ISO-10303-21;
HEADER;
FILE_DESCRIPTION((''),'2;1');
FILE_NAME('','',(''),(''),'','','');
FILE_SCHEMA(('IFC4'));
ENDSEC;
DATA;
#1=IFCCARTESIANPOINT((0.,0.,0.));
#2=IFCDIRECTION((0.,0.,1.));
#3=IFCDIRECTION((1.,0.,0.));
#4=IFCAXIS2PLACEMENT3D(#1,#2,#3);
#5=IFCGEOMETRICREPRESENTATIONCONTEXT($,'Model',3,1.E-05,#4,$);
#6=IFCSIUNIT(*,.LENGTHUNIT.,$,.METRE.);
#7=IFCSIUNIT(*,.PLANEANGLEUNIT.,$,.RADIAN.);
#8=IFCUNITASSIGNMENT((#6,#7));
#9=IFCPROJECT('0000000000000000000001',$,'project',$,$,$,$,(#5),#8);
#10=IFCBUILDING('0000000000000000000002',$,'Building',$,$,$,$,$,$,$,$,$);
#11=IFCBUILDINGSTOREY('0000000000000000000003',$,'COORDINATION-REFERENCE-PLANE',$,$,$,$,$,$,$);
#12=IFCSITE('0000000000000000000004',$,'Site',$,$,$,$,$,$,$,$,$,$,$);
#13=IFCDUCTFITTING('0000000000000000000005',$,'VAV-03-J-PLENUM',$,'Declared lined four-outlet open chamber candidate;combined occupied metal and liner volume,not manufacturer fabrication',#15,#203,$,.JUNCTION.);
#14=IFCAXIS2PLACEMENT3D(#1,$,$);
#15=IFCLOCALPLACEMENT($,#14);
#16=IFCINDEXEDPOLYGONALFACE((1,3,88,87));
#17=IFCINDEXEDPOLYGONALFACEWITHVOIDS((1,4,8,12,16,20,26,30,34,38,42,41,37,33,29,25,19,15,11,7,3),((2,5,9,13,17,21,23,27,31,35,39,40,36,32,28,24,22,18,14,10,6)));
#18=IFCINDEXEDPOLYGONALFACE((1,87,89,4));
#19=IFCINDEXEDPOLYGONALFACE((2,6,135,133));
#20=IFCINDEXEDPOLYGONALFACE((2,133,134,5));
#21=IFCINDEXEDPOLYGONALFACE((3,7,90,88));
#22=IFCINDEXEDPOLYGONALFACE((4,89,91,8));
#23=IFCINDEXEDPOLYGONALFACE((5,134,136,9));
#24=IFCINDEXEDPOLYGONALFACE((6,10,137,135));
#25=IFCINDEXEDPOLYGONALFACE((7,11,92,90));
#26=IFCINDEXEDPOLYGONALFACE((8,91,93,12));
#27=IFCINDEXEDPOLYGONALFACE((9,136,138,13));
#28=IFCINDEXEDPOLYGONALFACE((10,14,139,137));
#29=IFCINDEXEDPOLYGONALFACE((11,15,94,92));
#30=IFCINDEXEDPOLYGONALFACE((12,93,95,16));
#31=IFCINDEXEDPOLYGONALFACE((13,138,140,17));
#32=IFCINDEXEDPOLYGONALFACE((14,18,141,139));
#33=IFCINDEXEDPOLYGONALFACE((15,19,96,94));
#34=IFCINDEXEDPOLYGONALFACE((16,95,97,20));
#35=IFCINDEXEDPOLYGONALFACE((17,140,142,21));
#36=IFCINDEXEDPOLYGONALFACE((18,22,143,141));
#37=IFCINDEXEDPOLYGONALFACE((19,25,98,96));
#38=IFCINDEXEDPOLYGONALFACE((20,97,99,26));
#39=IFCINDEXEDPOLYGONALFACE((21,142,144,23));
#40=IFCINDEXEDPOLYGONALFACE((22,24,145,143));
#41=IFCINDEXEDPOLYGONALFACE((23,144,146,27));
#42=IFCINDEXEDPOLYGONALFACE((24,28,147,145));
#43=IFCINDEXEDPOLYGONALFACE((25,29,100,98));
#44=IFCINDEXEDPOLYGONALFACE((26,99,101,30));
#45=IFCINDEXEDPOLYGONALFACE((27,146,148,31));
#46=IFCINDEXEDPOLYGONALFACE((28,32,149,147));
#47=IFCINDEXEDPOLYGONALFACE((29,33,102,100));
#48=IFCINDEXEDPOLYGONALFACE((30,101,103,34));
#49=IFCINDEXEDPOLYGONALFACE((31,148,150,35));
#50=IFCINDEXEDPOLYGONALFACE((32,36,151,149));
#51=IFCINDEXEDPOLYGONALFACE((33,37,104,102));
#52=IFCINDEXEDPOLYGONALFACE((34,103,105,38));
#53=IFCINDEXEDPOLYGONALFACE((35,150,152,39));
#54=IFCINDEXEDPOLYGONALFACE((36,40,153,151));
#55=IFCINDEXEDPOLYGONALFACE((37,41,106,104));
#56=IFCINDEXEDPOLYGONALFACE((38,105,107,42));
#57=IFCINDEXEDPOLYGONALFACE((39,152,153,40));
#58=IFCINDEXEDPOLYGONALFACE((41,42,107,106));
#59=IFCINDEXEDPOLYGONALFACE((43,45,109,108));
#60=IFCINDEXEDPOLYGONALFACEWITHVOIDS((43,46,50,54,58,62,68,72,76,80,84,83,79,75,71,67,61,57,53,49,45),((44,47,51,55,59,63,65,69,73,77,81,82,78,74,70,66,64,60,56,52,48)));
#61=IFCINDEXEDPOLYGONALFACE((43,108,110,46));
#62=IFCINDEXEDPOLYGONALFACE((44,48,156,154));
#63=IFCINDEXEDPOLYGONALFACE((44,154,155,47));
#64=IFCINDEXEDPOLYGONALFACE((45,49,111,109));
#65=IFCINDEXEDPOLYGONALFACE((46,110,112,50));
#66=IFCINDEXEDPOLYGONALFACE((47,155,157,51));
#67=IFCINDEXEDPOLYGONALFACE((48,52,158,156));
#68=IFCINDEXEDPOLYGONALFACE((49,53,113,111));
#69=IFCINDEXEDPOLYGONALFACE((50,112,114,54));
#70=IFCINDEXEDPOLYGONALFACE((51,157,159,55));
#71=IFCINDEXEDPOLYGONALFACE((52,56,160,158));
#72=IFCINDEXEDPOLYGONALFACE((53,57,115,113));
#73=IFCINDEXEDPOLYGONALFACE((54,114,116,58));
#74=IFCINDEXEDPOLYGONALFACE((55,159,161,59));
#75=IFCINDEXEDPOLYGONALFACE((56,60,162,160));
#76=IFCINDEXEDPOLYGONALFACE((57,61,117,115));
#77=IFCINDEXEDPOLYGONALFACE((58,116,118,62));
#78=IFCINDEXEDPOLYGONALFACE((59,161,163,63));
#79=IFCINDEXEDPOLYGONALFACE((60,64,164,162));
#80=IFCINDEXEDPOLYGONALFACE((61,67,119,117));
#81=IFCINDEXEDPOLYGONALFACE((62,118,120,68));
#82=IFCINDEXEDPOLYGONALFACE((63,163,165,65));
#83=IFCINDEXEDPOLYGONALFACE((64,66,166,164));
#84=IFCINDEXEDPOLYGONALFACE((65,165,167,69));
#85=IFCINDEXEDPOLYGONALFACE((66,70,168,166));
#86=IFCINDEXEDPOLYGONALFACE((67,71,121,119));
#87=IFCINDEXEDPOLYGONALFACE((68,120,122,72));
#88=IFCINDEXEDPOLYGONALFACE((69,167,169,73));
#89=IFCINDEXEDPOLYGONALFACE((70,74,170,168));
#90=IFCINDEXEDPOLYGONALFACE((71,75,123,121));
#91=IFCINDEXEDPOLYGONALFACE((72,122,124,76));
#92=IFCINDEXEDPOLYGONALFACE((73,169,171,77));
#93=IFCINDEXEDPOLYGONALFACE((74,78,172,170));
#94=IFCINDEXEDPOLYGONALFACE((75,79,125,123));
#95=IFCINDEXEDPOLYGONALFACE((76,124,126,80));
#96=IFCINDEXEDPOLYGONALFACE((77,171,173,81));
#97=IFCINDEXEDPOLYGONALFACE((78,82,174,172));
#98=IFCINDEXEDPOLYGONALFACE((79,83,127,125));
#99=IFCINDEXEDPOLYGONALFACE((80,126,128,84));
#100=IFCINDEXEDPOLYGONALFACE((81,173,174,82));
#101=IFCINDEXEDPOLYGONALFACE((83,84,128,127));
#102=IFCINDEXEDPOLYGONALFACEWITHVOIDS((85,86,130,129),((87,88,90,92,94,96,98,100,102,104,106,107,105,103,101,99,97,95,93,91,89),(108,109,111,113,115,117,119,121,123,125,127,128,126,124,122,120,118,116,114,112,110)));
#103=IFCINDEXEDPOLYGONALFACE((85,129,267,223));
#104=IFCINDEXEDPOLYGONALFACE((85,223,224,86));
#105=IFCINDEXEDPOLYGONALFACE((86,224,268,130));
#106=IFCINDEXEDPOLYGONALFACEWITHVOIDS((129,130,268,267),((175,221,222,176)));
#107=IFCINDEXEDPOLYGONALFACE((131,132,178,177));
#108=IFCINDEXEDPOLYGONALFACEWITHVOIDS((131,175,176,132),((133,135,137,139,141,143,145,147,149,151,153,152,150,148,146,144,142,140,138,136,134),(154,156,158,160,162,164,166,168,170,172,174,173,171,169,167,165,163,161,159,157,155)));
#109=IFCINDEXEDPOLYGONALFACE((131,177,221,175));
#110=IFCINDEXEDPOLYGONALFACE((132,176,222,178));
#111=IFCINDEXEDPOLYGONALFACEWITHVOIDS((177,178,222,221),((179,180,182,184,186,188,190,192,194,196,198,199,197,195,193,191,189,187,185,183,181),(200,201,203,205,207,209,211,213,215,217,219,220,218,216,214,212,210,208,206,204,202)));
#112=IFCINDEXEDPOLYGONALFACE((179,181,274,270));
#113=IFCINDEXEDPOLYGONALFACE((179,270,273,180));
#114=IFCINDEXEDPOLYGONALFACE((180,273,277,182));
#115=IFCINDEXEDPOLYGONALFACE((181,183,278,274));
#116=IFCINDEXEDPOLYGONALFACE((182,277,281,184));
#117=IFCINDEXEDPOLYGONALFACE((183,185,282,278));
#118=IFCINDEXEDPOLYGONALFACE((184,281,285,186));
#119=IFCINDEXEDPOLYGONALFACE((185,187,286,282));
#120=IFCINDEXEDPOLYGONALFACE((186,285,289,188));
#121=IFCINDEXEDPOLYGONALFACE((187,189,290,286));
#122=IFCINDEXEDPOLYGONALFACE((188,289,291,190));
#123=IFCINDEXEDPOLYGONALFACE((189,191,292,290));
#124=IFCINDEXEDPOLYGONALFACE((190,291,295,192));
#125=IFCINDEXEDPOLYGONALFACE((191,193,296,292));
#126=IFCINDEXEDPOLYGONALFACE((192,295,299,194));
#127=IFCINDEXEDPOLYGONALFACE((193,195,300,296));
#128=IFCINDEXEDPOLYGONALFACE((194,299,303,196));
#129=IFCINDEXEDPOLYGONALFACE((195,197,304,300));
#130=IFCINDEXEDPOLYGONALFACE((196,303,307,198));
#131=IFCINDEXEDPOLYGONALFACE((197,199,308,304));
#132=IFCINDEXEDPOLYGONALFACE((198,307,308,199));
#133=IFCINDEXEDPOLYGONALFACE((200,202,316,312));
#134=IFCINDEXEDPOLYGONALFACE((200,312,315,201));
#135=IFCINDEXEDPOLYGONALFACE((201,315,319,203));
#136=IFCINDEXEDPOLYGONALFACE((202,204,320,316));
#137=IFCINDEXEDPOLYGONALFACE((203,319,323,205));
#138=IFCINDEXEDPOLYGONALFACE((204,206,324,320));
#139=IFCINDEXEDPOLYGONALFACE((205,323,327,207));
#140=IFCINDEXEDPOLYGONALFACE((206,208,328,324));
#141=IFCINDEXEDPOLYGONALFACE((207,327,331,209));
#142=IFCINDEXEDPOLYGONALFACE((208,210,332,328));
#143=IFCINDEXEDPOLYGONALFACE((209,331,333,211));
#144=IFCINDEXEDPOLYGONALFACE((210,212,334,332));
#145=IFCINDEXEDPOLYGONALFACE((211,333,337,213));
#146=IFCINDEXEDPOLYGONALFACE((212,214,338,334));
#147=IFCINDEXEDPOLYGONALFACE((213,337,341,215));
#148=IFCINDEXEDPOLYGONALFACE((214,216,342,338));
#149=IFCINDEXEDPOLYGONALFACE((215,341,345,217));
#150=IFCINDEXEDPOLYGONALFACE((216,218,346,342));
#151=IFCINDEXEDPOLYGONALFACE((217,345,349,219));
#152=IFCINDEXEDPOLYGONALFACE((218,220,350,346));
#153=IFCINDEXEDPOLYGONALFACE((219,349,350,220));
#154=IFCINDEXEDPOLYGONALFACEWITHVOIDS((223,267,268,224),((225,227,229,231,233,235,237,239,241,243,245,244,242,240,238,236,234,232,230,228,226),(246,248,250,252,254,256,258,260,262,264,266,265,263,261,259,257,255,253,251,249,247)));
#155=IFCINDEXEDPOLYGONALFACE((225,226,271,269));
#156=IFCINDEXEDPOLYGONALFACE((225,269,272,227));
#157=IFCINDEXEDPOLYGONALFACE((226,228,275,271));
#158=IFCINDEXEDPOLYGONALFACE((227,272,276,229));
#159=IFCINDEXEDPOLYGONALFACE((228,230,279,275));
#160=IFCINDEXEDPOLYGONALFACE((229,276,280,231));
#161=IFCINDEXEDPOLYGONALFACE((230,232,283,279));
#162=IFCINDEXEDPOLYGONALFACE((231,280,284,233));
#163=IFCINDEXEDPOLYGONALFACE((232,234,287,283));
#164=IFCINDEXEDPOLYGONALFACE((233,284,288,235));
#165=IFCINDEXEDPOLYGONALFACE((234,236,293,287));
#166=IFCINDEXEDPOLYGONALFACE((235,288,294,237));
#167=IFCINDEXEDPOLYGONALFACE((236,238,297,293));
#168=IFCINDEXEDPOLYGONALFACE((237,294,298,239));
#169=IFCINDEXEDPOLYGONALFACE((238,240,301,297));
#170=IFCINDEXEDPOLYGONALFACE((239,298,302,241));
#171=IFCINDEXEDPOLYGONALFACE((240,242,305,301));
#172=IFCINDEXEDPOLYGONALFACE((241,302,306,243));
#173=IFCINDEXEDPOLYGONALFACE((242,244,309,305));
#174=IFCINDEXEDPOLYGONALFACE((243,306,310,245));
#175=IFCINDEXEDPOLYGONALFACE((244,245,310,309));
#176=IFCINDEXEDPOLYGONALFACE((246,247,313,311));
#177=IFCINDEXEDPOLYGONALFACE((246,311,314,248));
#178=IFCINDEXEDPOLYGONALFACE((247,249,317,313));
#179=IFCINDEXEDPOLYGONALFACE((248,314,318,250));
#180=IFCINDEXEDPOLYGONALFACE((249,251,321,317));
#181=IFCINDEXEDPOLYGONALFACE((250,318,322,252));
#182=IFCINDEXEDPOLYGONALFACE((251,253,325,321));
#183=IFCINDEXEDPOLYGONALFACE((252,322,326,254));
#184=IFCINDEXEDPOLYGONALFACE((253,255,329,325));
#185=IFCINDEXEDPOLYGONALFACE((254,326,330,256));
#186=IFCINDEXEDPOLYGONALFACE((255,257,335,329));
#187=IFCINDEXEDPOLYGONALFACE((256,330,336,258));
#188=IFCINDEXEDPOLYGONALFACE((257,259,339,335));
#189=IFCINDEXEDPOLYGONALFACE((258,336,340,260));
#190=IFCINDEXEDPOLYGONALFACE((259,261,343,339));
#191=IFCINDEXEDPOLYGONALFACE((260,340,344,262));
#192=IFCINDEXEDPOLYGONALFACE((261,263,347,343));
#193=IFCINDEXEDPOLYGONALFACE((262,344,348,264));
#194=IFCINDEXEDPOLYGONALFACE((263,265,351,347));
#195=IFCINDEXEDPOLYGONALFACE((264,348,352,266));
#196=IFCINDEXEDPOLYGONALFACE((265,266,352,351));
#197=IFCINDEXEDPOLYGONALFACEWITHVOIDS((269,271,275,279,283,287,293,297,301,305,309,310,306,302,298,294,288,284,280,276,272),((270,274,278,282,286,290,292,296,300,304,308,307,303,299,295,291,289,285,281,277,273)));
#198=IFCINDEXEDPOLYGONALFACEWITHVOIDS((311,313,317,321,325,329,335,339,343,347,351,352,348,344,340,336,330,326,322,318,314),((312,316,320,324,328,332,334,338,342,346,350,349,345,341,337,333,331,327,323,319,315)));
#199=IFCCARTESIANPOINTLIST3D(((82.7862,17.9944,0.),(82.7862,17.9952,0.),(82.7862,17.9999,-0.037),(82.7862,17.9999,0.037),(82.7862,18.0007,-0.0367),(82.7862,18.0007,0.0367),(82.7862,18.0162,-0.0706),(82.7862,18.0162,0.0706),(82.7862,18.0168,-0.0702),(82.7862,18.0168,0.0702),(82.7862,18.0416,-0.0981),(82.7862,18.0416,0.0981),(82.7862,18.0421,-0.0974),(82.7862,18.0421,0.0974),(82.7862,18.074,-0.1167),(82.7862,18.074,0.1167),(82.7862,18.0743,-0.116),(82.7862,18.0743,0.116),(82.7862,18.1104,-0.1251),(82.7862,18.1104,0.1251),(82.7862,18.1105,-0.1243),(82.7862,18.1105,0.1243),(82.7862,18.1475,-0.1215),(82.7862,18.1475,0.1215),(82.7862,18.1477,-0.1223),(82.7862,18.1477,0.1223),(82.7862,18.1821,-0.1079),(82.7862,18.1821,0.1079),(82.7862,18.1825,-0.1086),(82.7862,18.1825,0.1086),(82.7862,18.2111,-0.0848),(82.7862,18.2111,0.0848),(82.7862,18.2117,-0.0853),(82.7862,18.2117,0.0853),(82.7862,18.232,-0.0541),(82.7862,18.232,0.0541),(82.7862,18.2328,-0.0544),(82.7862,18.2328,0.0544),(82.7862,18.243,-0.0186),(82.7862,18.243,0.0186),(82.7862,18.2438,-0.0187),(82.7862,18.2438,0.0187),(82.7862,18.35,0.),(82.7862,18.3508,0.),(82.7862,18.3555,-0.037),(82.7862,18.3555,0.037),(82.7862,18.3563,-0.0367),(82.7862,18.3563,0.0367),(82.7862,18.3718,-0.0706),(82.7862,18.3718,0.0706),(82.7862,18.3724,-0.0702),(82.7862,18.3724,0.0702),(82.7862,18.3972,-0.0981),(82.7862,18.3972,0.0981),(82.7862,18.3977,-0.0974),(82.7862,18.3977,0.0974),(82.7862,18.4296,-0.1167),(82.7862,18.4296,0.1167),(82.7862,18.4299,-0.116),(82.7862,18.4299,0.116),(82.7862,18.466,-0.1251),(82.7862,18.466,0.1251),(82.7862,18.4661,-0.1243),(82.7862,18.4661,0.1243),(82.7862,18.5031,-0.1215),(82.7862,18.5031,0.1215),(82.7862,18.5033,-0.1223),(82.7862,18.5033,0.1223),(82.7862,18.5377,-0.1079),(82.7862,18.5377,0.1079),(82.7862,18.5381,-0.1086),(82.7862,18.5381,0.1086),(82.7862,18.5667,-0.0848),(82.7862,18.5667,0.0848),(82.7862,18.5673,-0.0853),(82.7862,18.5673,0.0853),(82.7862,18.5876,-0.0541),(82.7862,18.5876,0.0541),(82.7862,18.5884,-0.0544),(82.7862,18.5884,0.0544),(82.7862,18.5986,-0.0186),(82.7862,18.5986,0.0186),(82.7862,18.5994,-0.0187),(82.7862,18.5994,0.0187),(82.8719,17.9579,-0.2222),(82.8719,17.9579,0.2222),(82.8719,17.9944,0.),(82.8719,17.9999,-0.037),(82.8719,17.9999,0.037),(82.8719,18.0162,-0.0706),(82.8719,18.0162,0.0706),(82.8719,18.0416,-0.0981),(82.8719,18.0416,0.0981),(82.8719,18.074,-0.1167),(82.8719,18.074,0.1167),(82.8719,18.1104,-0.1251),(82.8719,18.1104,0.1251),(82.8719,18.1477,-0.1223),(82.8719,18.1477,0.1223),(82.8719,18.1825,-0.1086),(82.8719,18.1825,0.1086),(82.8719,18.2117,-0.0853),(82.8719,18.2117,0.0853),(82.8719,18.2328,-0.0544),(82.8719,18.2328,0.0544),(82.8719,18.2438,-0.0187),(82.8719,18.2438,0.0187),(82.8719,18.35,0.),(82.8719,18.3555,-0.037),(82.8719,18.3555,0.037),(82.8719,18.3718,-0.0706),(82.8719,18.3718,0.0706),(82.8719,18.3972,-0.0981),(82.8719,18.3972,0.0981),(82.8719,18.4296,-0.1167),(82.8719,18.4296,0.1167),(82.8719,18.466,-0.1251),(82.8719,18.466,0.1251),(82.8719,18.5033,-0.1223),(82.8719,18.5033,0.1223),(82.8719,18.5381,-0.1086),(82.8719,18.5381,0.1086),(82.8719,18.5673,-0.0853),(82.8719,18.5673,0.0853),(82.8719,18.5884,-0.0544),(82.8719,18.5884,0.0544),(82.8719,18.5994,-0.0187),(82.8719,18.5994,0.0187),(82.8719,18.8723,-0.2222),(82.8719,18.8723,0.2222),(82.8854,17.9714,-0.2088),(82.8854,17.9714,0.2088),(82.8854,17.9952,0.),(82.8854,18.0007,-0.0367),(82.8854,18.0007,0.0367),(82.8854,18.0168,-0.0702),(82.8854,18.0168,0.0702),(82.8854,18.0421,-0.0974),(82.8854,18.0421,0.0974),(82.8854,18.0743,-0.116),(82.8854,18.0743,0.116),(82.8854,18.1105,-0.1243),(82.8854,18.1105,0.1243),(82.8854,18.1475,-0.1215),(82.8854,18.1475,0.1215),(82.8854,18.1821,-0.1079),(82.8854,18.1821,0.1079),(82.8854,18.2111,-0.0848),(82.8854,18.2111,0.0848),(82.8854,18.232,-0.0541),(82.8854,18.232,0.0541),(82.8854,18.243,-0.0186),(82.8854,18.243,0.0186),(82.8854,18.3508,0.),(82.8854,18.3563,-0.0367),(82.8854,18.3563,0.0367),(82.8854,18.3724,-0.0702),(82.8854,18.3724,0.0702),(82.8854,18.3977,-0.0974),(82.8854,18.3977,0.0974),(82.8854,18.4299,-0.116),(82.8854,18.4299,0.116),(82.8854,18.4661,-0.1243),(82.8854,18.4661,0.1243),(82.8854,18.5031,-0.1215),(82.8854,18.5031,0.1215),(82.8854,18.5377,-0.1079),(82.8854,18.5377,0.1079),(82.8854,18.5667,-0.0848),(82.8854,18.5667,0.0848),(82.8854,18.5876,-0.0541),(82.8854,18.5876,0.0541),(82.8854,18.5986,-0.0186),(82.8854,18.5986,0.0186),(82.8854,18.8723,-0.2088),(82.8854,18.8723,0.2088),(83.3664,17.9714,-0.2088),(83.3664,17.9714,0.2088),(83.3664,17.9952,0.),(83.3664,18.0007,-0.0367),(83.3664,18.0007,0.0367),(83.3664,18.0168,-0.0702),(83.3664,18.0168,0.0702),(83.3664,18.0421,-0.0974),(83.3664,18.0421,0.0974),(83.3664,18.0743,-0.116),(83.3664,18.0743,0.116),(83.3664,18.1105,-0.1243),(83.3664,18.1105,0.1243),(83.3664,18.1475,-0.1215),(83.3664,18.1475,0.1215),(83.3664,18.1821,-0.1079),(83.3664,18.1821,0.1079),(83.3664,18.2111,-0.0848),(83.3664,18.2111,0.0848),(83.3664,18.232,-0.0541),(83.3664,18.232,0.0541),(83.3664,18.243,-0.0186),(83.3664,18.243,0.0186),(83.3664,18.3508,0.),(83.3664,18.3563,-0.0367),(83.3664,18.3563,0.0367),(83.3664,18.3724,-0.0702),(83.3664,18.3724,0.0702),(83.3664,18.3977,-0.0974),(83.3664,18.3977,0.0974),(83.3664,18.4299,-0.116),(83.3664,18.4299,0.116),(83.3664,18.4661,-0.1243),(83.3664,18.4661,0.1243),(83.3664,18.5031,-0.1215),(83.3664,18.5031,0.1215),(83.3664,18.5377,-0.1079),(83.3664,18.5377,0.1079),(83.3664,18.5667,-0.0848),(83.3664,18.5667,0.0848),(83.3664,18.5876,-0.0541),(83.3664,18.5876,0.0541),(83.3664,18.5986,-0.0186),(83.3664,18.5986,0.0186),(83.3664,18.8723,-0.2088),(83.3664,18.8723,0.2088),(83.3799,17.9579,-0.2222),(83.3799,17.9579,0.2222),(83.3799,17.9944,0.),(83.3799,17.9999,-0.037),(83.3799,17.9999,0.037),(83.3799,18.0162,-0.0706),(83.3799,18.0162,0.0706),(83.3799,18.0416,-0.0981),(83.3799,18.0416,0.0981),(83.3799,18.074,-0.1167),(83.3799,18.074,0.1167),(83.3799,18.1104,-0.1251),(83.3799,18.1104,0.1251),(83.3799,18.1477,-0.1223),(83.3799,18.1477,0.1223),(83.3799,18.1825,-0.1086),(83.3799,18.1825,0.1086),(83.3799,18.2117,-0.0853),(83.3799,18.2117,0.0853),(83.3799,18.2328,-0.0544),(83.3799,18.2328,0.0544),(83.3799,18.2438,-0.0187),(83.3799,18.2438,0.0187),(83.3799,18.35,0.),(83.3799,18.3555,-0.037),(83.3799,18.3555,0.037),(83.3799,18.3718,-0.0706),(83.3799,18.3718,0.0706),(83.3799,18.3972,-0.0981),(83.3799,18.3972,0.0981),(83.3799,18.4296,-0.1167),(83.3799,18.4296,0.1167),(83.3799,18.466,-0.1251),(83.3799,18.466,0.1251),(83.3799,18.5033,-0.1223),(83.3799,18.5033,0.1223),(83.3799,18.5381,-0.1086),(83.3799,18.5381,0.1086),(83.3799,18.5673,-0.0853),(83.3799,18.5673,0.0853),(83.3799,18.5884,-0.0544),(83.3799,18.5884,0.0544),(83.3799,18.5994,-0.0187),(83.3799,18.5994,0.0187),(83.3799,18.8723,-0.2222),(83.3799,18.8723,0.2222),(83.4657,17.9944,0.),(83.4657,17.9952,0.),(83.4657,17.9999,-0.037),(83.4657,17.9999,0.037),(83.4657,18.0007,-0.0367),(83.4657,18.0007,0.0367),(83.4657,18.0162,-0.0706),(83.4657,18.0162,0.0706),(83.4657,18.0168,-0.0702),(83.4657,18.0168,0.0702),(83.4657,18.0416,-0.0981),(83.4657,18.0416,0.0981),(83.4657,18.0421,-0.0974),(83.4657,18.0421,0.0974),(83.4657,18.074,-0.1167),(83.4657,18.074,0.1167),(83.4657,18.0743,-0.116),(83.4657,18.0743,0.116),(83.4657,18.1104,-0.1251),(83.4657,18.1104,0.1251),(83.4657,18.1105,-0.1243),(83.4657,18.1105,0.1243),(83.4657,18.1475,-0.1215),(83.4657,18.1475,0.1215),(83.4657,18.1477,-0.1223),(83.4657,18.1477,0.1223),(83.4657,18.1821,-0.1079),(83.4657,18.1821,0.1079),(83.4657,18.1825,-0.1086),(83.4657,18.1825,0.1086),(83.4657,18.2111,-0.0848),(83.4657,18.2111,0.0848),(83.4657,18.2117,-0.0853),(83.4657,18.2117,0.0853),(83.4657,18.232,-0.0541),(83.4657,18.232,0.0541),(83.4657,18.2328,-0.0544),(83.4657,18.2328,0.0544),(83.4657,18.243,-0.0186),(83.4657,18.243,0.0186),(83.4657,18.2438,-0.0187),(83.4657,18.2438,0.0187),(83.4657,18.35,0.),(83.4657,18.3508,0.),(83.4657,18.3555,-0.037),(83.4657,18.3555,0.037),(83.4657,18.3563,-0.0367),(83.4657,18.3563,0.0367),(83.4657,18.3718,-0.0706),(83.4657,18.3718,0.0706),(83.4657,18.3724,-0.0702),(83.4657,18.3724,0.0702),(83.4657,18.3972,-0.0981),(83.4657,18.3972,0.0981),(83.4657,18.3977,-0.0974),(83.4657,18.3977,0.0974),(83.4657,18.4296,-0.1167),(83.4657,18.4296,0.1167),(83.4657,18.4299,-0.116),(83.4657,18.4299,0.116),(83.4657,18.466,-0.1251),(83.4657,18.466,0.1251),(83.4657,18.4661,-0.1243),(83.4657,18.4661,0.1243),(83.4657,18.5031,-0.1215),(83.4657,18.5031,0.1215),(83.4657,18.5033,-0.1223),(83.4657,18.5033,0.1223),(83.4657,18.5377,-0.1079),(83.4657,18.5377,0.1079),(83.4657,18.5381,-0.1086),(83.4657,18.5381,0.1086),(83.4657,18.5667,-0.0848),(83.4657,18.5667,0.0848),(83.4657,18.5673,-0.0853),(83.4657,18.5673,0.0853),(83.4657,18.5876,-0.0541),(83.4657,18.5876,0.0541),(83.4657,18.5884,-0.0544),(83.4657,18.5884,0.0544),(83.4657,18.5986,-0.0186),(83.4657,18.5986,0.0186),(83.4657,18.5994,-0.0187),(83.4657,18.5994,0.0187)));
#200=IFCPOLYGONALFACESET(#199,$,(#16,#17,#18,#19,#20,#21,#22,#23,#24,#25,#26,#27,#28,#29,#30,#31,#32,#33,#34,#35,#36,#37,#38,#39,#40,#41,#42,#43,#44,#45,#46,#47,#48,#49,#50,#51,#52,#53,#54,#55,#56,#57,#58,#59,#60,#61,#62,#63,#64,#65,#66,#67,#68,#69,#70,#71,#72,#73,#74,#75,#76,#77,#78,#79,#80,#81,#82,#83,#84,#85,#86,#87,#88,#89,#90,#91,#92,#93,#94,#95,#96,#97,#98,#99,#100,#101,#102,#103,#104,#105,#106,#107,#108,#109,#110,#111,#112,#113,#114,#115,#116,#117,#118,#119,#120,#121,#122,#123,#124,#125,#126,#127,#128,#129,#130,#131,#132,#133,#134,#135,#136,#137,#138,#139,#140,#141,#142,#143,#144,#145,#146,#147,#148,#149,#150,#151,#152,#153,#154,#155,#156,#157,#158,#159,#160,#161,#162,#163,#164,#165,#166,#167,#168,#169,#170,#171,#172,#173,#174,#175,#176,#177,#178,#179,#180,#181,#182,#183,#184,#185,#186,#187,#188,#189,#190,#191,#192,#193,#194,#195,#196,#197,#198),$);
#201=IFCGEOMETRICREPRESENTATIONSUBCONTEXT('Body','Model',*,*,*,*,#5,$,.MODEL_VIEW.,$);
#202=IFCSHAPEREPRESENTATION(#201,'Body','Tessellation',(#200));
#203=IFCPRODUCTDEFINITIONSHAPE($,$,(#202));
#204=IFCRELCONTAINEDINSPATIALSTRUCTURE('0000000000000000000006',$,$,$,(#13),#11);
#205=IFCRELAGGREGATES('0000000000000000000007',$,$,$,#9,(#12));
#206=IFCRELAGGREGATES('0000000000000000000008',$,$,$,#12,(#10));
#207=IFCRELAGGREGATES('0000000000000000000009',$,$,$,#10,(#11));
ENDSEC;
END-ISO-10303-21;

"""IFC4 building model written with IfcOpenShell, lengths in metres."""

from ifc_helpers import new_model, si_unit, frame, origin_with_axes, place, context, subcontext, project, spatial, rectangle, circle, extrude, boolean, element, save


model = new_model("IFC4")

# Units and contexts
model_context = context("Model", 3, precision=1e-05, world=origin_with_axes())
body_context_1 = subcontext(model_context, "Body", "Model", "MODEL_VIEW")
ifc_project = project(units=[si_unit("LENGTHUNIT", "METRE"), si_unit("PLANEANGLEUNIT", "RADIAN")], contexts=[model_context])

# Site, building, storey
site = spatial("IfcSite", under=ifc_project, Name="Site")
building = spatial("IfcBuilding", under=site, Name="Building")
storey = spatial("IfcBuildingStorey", under=building, Name="COORDINATION-REFERENCE-PLANE")

# Duct fitting
duct_fitting_1_placement = place(None, frame((82.8719, 17.9579, -0.2223), z_axis=(0.0, 0.0, 1.0), x_axis=(1.0, 0.0, 0.0)))
solid_1 = boolean("UNION", boolean("UNION", boolean("UNION", boolean("UNION", extrude(rectangle(XDim=0.481, YDim=0.4175), frame((0.254, 0.9244, 0.2223), z_axis=(0.0, -1.0, 0.0), x_axis=(1.0, 0.0, 0.0)), (0.0, 0.0, 1.0), 0.9109), extrude(circle(Radius=0.1246), frame((0.0235, 0.5175, 0.2223), z_axis=(-1.0, 0.0, 0.0), x_axis=(0.0, -1.0, 0.0)), (0.0, 0.0, 1.0), 0.1192)), extrude(circle(Radius=0.1246), frame((0.4845, 0.5175, 0.2223), z_axis=(1.0, 0.0, 0.0), x_axis=(0.0, -1.0, 0.0)), (0.0, 0.0, 1.0), 0.1192)), extrude(circle(Radius=0.1246), frame((0.0235, 0.1619, 0.2223), z_axis=(-1.0, 0.0, 0.0), x_axis=(0.0, -1.0, 0.0)), (0.0, 0.0, 1.0), 0.1192)), extrude(circle(Radius=0.1246), frame((0.4845, 0.1619, 0.2223), z_axis=(1.0, 0.0, 0.0), x_axis=(0.0, -1.0, 0.0)), (0.0, 0.0, 1.0), 0.1192))
element("IfcDuctFitting", 1, at=duct_fitting_1_placement, inside=storey, Name="VAV-03-J-PLENUM", ObjectType="Declared lined four-outlet open chamber candidate;combined occupied metal and liner volume,not manufacturer fabrication", PredefinedType="JUNCTION", context=body_context_1, shape_type="CSG", body=[
    boolean("DIFFERENCE", boolean("UNION", boolean("UNION", boolean("UNION", boolean("UNION", extrude(rectangle(XDim=0.508, YDim=0.4445), frame((0.254, 0.9144, 0.2223), z_axis=(0.0, -1.0, 0.0), x_axis=(1.0, 0.0, 0.0)), (0.0, 0.0, 1.0), 0.9144), extrude(circle(Radius=0.1254), frame((0.0235, 0.5175, 0.2223), z_axis=(-1.0, 0.0, 0.0), x_axis=(0.0, -1.0, 0.0)), (0.0, 0.0, 1.0), 0.1092)), extrude(circle(Radius=0.1254), frame((0.4845, 0.5175, 0.2223), z_axis=(1.0, 0.0, 0.0), x_axis=(0.0, -1.0, 0.0)), (0.0, 0.0, 1.0), 0.1092)), extrude(circle(Radius=0.1254), frame((0.0235, 0.1619, 0.2223), z_axis=(-1.0, 0.0, 0.0), x_axis=(0.0, -1.0, 0.0)), (0.0, 0.0, 1.0), 0.1092)), extrude(circle(Radius=0.1254), frame((0.4845, 0.1619, 0.2223), z_axis=(1.0, 0.0, 0.0), x_axis=(0.0, -1.0, 0.0)), (0.0, 0.0, 1.0), 0.1092)), solid_1),
])

save(model, "model.ifc")
